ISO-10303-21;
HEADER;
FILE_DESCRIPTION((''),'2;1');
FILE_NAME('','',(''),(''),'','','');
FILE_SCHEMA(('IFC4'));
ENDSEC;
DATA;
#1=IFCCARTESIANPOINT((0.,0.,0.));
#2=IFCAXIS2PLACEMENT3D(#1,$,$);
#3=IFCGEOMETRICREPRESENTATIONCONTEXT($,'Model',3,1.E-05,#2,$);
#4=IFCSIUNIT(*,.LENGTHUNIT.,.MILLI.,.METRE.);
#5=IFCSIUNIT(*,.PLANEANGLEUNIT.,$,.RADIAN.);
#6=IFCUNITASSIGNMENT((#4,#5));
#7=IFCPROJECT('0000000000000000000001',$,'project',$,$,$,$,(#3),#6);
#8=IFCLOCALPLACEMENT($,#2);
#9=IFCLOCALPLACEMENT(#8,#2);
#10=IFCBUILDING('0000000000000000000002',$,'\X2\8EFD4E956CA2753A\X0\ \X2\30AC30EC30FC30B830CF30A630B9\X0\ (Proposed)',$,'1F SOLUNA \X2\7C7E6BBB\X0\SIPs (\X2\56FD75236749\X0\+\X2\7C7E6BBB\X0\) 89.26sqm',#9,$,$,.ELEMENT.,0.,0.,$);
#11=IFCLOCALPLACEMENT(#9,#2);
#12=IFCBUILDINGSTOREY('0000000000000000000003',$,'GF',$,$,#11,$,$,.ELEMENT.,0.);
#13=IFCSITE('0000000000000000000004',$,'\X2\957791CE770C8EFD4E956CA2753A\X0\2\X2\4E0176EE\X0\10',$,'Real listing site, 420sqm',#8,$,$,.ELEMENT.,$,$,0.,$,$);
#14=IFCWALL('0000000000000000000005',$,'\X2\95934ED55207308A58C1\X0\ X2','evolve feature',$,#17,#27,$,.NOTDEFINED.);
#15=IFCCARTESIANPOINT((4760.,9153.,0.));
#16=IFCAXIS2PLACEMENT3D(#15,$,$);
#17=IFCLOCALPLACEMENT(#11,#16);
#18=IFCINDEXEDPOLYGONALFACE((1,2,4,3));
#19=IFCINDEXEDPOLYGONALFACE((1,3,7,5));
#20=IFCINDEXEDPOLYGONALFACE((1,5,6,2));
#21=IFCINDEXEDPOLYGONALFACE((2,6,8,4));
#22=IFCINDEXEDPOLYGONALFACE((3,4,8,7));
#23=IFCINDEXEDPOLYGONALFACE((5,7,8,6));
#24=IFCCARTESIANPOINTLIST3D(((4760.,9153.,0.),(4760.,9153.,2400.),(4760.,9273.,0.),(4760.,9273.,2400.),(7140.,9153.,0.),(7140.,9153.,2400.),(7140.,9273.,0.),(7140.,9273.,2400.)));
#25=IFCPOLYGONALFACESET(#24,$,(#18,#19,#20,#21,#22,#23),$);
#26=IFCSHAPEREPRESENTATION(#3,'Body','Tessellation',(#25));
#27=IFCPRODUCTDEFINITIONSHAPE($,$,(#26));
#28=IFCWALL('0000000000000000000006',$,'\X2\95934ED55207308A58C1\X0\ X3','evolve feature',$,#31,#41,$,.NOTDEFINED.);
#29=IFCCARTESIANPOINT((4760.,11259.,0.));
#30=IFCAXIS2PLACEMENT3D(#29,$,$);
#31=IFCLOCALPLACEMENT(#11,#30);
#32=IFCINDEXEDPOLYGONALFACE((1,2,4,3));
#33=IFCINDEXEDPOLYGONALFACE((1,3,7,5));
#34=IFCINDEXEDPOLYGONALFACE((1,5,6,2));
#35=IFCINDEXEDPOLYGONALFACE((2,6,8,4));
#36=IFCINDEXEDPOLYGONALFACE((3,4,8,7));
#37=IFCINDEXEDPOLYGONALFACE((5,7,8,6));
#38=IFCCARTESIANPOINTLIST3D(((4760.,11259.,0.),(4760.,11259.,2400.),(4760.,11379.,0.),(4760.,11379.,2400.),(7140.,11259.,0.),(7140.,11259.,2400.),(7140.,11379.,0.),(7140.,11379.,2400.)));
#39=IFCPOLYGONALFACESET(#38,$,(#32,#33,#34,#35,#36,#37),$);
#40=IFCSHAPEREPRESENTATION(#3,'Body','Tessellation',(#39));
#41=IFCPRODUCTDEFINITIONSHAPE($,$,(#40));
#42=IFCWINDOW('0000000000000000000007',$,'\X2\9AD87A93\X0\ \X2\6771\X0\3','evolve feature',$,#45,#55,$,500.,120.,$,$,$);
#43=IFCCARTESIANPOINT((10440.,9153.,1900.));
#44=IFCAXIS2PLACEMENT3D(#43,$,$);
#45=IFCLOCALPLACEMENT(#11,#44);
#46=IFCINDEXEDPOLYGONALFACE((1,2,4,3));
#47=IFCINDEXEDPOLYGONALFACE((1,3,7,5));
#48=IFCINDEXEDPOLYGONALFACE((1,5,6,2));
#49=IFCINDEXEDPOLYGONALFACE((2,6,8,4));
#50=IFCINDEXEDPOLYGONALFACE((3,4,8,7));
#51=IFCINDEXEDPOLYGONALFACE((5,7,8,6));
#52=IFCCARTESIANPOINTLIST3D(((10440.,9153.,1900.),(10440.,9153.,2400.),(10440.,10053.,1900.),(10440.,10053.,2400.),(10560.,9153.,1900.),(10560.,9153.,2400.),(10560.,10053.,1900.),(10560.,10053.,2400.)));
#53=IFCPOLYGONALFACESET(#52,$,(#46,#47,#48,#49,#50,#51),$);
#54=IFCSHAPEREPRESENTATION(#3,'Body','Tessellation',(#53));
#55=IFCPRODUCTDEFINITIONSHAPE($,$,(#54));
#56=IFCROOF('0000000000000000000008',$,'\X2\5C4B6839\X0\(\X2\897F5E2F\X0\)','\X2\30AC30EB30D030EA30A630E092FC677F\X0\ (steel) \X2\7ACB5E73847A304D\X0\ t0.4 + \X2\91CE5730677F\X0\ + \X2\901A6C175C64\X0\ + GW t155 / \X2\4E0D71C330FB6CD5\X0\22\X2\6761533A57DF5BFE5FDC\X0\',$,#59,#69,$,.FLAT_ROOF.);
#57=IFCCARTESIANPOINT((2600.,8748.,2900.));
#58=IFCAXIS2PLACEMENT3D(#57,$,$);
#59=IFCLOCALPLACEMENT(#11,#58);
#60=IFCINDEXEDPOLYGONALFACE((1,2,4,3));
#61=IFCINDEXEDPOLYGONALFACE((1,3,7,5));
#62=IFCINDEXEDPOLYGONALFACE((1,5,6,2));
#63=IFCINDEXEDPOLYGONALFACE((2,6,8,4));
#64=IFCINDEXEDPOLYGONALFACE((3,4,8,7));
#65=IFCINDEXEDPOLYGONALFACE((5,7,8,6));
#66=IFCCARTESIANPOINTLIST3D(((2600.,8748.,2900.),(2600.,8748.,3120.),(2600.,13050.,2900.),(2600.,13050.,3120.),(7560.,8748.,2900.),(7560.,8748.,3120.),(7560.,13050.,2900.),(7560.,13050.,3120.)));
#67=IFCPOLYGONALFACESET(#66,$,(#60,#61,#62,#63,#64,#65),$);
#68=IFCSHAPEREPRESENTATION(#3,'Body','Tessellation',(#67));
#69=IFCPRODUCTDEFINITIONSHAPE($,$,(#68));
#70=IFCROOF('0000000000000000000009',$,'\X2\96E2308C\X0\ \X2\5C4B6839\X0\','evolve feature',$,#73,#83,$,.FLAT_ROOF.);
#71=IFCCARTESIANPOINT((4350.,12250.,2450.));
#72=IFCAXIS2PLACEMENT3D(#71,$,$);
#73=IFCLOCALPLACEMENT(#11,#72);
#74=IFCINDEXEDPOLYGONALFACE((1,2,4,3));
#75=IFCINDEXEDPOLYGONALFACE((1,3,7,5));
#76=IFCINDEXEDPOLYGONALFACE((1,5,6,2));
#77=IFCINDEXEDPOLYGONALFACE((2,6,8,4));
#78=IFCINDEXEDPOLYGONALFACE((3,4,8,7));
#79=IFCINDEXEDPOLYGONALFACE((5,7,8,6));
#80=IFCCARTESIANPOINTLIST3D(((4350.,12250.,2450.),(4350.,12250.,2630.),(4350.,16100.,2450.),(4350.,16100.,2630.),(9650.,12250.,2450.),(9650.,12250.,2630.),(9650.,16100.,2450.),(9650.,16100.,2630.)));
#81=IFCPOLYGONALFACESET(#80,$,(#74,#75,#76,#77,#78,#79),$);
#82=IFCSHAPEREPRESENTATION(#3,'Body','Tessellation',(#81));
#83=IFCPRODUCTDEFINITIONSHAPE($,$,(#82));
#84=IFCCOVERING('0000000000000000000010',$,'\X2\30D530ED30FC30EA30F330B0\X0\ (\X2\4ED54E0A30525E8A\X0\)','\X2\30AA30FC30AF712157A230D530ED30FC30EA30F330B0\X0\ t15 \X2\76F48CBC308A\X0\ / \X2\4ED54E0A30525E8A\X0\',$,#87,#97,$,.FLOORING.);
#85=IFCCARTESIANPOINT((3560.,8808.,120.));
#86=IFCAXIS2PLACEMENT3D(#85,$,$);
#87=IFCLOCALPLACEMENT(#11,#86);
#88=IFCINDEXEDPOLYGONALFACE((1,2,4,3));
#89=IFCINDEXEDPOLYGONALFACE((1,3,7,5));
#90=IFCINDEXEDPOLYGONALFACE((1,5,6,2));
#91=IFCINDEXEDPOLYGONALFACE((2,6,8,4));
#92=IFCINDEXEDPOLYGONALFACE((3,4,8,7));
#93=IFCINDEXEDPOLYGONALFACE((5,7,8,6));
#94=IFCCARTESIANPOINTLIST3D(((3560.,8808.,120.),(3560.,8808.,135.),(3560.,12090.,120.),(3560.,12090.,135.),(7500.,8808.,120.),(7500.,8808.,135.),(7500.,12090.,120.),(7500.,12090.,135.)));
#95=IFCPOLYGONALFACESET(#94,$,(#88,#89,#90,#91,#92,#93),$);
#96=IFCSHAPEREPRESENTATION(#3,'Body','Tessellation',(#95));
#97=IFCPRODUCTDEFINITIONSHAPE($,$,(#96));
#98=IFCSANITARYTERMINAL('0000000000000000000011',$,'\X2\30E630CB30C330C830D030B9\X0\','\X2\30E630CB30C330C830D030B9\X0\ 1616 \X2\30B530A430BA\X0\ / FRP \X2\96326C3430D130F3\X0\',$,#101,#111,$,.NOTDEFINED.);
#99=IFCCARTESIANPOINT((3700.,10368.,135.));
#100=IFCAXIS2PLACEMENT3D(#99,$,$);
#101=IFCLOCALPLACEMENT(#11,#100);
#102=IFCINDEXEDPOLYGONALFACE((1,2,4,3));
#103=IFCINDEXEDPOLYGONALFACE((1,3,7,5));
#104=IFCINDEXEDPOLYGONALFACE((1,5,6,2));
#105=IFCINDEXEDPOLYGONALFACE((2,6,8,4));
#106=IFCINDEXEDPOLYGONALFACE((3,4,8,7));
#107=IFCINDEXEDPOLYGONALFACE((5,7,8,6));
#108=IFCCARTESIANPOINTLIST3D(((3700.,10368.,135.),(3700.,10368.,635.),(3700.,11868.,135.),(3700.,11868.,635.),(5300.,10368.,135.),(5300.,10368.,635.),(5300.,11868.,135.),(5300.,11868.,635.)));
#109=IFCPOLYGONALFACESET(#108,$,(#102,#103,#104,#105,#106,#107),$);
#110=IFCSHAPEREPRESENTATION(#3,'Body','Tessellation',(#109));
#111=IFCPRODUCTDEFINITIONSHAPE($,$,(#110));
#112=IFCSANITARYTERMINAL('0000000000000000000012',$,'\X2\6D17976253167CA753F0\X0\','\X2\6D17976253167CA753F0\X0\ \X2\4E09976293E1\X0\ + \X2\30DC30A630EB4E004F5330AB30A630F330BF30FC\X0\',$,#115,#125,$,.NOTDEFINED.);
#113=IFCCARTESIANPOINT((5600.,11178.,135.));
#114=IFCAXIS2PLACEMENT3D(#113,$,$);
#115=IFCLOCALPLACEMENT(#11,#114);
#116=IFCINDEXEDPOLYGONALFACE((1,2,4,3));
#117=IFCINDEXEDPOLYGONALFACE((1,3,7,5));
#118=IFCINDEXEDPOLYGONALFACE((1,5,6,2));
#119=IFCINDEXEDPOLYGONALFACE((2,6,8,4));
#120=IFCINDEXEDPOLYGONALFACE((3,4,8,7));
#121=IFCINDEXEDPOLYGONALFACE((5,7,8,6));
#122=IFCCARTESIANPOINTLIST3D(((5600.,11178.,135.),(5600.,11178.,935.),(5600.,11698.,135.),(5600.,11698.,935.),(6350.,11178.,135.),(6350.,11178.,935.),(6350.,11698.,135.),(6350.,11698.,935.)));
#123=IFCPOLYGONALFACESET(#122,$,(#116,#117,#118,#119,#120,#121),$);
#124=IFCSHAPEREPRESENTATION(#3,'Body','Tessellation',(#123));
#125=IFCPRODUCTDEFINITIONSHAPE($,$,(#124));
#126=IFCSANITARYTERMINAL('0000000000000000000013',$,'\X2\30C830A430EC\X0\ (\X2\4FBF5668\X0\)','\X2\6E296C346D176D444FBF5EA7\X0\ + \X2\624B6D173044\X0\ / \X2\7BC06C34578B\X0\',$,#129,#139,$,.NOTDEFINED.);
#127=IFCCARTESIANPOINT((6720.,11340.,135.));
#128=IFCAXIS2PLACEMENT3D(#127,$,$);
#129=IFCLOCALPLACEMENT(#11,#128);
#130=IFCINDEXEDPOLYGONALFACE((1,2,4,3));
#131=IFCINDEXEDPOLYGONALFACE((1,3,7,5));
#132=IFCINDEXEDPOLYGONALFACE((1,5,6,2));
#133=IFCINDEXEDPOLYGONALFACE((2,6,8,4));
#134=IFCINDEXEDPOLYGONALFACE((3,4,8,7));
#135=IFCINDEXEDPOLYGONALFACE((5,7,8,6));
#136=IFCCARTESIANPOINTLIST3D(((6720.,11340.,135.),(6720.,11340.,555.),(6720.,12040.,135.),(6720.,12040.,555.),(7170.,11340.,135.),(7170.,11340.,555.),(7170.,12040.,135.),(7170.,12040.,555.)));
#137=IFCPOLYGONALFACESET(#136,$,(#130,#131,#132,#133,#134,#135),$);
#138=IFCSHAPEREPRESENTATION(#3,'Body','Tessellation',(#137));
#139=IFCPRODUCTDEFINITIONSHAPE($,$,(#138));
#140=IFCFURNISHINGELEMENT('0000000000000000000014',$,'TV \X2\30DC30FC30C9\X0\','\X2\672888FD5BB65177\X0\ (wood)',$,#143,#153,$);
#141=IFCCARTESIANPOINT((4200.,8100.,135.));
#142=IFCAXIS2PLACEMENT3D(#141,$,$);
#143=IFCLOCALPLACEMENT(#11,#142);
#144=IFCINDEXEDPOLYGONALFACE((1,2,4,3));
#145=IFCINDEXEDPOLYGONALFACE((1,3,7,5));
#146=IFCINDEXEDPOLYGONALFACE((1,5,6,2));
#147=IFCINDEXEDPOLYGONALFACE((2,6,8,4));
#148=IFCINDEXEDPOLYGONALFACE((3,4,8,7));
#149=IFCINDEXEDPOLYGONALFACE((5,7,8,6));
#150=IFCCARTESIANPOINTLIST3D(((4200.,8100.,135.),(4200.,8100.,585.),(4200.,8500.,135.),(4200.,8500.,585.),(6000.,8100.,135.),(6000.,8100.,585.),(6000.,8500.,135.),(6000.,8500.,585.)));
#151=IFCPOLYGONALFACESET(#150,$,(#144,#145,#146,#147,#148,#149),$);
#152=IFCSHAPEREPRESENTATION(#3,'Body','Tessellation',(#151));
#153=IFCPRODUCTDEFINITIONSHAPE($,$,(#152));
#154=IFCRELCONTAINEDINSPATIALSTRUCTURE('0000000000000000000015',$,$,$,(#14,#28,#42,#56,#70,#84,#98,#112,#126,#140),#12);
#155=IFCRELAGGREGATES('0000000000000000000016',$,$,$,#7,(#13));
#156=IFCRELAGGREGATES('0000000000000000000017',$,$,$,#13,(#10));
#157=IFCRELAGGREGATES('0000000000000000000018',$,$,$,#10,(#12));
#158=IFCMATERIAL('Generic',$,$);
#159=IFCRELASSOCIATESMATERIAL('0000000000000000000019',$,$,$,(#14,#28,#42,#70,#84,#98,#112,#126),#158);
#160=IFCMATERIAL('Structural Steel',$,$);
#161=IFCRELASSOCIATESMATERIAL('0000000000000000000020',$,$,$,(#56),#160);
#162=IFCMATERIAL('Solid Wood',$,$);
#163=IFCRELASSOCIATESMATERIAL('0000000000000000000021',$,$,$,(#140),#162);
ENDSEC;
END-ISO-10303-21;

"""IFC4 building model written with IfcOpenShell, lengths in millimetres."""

from ifc_helpers import new_model, si_unit, frame, frame_2d, origin, place, context, project, spatial, rectangle, extrude, material, element, save


model = new_model("IFC4")

# Units and contexts
model_context = context("Model", 3, precision=1e-05, world=origin())
ifc_project = project(units=[si_unit("LENGTHUNIT", "METRE", prefix="MILLI"), si_unit("PLANEANGLEUNIT", "RADIAN")], contexts=[model_context])

# Site, building, storey
site_placement = place(None, origin())
site = spatial("IfcSite", under=ifc_project, at=site_placement, Name="長野県軽井沢町2丁目10", ObjectType="Real listing site, 420sqm", CompositionType="ELEMENT", RefElevation=0.0)
building_placement = place(site_placement, origin())
building = spatial("IfcBuilding", under=site, at=building_placement, Name="軽井沢町 ガレージハウス (Proposed)", ObjectType="1F SOLUNA 籾殻SIPs (国産杉+籾殻) 89.26sqm", CompositionType="ELEMENT", ElevationOfRefHeight=0.0, ElevationOfTerrain=0.0)
storey_placement = place(building_placement, origin())
storey = spatial("IfcBuildingStorey", under=building, at=storey_placement, Name="GF", CompositionType="ELEMENT", Elevation=0.0)

# Shared definitions
ifc_material_1 = material(Name="Solid Wood")
ifc_material_2 = material(Name="Generic")

# Walls
wall_1_placement = place(storey_placement, frame((4760.0, 9153.0, 0.0)))
element("IfcWall", 1, at=wall_1_placement, inside=storey, material=ifc_material_2, Name="間仕切り壁 X2", Description="evolve feature", PredefinedType="NOTDEFINED", context=model_context, shape_type="SweptSolid", body=[
    extrude(rectangle(XDim=2380.0, YDim=120.0, at=frame_2d((1190.0, 60.0))), frame((4760.0, 9153.0, 0.0)), (0.0, 0.0, 1.0), 2400.0),
])
wall_2_placement = place(storey_placement, frame((4760.0, 11259.0, 0.0)))
element("IfcWall", 2, at=wall_2_placement, inside=storey, material=ifc_material_2, Name="間仕切り壁 X3", Description="evolve feature", PredefinedType="NOTDEFINED", context=model_context, shape_type="SweptSolid", body=[
    extrude(rectangle(XDim=2380.0, YDim=120.0, at=frame_2d((1190.0, 60.0))), frame((4760.0, 11259.0, 0.0)), (0.0, 0.0, 1.0), 2400.0),
])

# Window
window_1_placement = place(storey_placement, frame((10440.0, 9153.0, 1900.0)))
element("IfcWindow", 3, at=window_1_placement, inside=storey, material=ifc_material_2, Name="高窓 東3", Description="evolve feature", OverallHeight=500.0, OverallWidth=120.0, context=model_context, shape_type="SweptSolid", body=[
    extrude(rectangle(XDim=120.0, YDim=900.0, at=frame_2d((60.0, 450.0))), frame((10440.0, 9153.0, 1900.0)), (0.0, 0.0, 1.0), 500.0),
])

# Roofs
ifc_material_3 = material(Name="Structural Steel")
roof_1_placement = place(storey_placement, frame((2600.0, 8748.0, 2900.0)))
element("IfcRoof", 4, at=roof_1_placement, inside=storey, material=ifc_material_3, Name="屋根(西帯)", Description="ガルバリウム鋼板 (steel) 立平葺き t0.4 + 野地板 + 通気層 + GW t155 / 不燃・法22条区域対応", PredefinedType="FLAT_ROOF", context=model_context, shape_type="SweptSolid", body=[
    extrude(rectangle(XDim=4960.0, YDim=4302.0, at=frame_2d((2480.0, 2151.0))), frame((2600.0, 8748.0, 2900.0)), (0.0, 0.0, 1.0), 220.0),
])
roof_2_placement = place(storey_placement, frame((4350.0, 12250.0, 2450.0)))
element("IfcRoof", 5, at=roof_2_placement, inside=storey, material=ifc_material_2, Name="離れ 屋根", Description="evolve feature", PredefinedType="FLAT_ROOF", context=model_context, shape_type="SweptSolid", body=[
    extrude(rectangle(XDim=5300.0, YDim=3850.0, at=frame_2d((2650.0, 1925.0))), frame((4350.0, 12250.0, 2450.0)), (0.0, 0.0, 1.0), 180.0),
])

# Covering
covering_placement = place(storey_placement, frame((3560.0, 8808.0, 120.0)))
element("IfcCovering", 6, at=covering_placement, inside=storey, material=ifc_material_2, Name="フローリング (仕上げ床)", Description="オーク無垢フローリング t15 直貼り / 仕上げ床", PredefinedType="FLOORING", context=model_context, shape_type="SweptSolid", body=[
    extrude(rectangle(XDim=3940.0, YDim=3282.0, at=frame_2d((1970.0, 1641.0))), frame((3560.0, 8808.0, 120.0)), (0.0, 0.0, 1.0), 15.0),
])

# Sanitary terminals
sanitary_terminal_1_placement = place(storey_placement, frame((3700.0, 10368.0, 135.0)))
element("IfcSanitaryTerminal", 7, at=sanitary_terminal_1_placement, inside=storey, material=ifc_material_2, Name="ユニットバス", Description="ユニットバス 1616 サイズ / FRP 防水パン", PredefinedType="NOTDEFINED", context=model_context, shape_type="SweptSolid", body=[
    extrude(rectangle(XDim=1600.0, YDim=1500.0, at=frame_2d((800.0, 750.0))), frame((3700.0, 10368.0, 135.0)), (0.0, 0.0, 1.0), 500.0),
])
sanitary_terminal_2_placement = place(storey_placement, frame((5600.0, 11178.0, 135.0)))
element("IfcSanitaryTerminal", 8, at=sanitary_terminal_2_placement, inside=storey, material=ifc_material_2, Name="洗面化粧台", Description="洗面化粧台 三面鏡 + ボウル一体カウンター", PredefinedType="NOTDEFINED", context=model_context, shape_type="SweptSolid", body=[
    extrude(rectangle(XDim=750.0, YDim=520.0, at=frame_2d((375.0, 260.0))), frame((5600.0, 11178.0, 135.0)), (0.0, 0.0, 1.0), 800.0),
])
sanitary_terminal_3_placement = place(storey_placement, frame((6720.0, 11340.0, 135.0)))
element("IfcSanitaryTerminal", 9, at=sanitary_terminal_3_placement, inside=storey, material=ifc_material_2, Name="トイレ (便器)", Description="温水洗浄便座 + 手洗い / 節水型", PredefinedType="NOTDEFINED", context=model_context, shape_type="SweptSolid", body=[
    extrude(rectangle(XDim=450.0, YDim=700.0, at=frame_2d((225.0, 350.0))), frame((6720.0, 11340.0, 135.0)), (0.0, 0.0, 1.0), 420.0),
])

# Furnishing element
furnishing_placement = place(storey_placement, frame((4200.0, 8100.0, 135.0)))
element("IfcFurnishingElement", 10, at=furnishing_placement, inside=storey, material=ifc_material_1, Name="TV ボード", Description="木製家具 (wood)", context=model_context, shape_type="SweptSolid", body=[
    extrude(rectangle(XDim=1800.0, YDim=400.0, at=frame_2d((900.0, 200.0))), frame((4200.0, 8100.0, 135.0)), (0.0, 0.0, 1.0), 450.0),
])

save(model, "model.ifc")
